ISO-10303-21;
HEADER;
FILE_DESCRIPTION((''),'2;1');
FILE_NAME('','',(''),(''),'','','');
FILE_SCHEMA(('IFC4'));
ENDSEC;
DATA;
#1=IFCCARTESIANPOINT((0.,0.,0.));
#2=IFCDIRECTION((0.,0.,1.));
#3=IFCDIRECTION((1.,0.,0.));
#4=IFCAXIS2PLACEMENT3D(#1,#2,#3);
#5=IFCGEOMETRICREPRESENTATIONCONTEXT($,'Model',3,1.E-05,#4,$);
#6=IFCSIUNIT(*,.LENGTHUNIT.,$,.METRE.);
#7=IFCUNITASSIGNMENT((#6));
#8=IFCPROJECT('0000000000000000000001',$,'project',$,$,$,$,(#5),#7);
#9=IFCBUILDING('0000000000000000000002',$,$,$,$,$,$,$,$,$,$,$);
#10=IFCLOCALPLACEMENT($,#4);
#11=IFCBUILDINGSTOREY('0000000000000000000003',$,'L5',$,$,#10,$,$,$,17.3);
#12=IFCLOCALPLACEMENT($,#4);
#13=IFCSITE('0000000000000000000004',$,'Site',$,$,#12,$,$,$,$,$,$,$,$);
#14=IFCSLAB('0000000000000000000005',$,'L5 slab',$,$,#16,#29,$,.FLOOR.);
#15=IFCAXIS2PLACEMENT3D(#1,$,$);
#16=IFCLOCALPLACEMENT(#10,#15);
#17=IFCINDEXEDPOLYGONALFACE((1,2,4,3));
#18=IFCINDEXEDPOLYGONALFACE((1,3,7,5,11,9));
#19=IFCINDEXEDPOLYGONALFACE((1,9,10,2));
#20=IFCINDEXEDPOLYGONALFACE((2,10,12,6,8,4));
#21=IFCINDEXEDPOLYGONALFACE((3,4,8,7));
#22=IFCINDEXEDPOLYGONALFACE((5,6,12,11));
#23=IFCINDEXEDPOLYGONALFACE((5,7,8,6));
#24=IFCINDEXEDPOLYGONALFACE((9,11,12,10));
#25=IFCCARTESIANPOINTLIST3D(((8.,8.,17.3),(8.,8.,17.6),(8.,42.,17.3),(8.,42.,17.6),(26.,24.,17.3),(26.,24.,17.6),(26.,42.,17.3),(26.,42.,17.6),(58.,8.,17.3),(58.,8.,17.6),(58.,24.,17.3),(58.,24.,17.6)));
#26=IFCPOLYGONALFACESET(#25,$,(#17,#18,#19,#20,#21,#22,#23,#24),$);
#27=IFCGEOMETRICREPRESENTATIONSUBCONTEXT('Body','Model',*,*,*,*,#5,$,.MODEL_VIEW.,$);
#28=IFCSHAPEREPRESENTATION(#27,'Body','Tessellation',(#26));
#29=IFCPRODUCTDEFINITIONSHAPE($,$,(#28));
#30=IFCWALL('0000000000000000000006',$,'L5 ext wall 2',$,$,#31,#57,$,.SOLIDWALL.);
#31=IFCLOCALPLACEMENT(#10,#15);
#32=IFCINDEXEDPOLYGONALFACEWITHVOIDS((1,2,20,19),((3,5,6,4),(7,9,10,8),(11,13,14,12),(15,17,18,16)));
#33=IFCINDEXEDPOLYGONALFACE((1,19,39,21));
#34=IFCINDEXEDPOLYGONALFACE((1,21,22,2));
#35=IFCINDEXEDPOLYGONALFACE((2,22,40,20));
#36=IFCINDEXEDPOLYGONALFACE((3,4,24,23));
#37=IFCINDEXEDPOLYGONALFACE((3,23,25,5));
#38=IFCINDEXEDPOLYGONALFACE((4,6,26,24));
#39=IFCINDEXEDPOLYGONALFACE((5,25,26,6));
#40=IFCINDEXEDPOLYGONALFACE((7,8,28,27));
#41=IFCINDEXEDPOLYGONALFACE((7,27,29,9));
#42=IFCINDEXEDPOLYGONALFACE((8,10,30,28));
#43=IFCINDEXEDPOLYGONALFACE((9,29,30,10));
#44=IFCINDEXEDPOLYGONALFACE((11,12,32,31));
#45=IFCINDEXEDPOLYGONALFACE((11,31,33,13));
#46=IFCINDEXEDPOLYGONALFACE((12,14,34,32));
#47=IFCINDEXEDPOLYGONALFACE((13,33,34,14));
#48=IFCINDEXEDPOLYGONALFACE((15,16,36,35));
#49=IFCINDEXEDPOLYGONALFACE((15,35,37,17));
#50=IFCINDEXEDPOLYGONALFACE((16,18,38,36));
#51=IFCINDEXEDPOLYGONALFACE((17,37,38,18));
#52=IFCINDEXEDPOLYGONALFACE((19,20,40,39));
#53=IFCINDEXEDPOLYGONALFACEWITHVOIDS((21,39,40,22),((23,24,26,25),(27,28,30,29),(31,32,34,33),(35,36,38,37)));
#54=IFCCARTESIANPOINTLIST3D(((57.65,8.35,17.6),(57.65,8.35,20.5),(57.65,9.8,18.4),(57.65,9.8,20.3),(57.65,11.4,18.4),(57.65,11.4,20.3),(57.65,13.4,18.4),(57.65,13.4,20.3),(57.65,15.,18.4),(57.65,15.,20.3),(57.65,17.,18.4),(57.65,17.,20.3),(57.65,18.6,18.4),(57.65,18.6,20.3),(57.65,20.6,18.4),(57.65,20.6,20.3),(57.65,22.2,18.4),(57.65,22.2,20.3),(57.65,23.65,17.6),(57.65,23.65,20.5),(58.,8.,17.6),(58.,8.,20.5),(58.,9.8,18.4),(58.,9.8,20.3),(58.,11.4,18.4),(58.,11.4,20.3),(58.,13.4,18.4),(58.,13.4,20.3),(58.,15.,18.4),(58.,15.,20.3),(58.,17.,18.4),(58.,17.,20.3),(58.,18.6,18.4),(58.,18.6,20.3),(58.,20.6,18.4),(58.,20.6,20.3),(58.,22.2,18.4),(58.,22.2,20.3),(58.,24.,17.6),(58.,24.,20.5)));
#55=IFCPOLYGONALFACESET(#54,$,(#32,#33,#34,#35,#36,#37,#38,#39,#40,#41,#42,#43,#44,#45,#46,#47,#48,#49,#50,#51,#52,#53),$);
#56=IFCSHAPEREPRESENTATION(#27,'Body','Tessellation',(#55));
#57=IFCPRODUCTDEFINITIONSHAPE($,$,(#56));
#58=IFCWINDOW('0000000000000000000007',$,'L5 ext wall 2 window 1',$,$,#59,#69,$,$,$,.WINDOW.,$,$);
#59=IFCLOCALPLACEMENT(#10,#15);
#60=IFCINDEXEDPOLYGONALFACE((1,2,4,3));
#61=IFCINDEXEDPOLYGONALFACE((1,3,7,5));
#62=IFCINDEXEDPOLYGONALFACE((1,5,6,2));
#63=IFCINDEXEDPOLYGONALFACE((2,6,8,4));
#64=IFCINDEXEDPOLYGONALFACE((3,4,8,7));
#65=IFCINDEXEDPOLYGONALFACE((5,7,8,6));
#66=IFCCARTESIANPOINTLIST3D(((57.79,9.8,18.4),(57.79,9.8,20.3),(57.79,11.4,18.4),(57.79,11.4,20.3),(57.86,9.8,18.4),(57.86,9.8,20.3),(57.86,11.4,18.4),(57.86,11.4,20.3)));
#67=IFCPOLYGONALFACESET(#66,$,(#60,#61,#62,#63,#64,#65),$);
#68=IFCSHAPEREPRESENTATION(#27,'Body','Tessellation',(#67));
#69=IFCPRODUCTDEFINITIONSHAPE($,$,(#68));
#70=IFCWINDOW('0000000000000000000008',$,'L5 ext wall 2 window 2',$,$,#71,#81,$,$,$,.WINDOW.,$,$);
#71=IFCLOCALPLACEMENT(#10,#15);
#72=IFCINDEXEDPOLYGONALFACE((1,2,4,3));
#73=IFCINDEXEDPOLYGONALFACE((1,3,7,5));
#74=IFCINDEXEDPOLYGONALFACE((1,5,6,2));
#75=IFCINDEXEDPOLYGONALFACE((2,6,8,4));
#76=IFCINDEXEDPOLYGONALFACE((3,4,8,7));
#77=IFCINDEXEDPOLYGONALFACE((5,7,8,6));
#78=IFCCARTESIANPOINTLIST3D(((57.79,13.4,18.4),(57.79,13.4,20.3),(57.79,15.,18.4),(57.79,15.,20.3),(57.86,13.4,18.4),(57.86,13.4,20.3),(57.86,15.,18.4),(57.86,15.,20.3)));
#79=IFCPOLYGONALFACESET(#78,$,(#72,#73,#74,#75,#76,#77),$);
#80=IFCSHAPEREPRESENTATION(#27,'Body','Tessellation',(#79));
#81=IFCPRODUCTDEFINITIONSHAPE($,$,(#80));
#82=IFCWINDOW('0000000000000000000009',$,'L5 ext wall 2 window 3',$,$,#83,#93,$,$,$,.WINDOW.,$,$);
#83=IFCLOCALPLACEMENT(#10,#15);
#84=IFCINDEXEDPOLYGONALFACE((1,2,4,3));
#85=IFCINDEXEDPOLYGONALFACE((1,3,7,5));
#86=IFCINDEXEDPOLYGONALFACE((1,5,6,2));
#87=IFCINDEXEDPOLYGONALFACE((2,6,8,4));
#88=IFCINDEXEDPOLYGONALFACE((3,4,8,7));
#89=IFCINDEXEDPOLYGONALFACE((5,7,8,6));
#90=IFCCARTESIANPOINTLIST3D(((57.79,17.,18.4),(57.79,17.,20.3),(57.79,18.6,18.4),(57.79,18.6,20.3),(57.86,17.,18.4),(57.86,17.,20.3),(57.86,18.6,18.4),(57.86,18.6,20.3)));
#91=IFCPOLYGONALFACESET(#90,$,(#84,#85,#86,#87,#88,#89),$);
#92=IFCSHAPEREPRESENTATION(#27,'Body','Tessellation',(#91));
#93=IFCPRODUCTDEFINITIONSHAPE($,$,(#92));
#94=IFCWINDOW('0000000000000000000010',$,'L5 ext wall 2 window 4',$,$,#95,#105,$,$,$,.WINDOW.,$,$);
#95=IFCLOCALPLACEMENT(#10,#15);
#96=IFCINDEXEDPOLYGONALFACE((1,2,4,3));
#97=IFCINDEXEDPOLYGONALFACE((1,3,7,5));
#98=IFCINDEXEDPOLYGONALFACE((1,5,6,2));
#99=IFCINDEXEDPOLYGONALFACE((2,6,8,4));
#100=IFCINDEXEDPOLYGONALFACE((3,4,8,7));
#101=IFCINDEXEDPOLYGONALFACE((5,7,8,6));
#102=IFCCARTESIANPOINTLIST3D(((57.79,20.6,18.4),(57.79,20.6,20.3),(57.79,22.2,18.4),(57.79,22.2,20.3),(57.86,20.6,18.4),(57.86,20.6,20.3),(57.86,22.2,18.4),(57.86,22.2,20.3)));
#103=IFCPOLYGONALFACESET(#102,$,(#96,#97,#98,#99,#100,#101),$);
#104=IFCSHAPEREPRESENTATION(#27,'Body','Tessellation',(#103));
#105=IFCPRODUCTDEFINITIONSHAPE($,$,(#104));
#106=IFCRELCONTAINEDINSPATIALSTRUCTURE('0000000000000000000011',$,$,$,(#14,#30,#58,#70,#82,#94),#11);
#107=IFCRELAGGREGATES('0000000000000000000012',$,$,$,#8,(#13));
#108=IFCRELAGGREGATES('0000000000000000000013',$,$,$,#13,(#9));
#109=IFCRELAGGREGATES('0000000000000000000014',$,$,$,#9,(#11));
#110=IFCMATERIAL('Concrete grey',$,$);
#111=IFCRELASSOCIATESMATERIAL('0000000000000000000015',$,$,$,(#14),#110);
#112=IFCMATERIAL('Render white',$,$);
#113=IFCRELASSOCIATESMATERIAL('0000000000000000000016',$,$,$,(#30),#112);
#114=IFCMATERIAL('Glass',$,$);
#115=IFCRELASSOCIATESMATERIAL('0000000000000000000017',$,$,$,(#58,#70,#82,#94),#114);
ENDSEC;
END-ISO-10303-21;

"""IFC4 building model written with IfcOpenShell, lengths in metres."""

from ifc_helpers import new_model, si_unit, frame, origin_with_axes, place, context, subcontext, project, spatial, polyline, outline, extrude, material, element, fill, save


model = new_model("IFC4")

# Units and contexts
model_context = context("Model", 3, precision=1e-05, world=origin_with_axes())
body_context = subcontext(model_context, "Body", "Model", "MODEL_VIEW")
ifc_project = project(units=[si_unit("LENGTHUNIT", "METRE")], contexts=[model_context])

# Site, building, storey
site_placement = place(None, origin_with_axes())
site = spatial("IfcSite", under=ifc_project, at=site_placement, Name="Site")
building = spatial("IfcBuilding", under=site)
storey_placement = place(None, origin_with_axes())
storey = spatial("IfcBuildingStorey", under=building, at=storey_placement, Name="L5", Elevation=17.3)

# Slab
ifc_material_1 = material(Name="Concrete grey")
slab_placement = place(storey_placement, origin_with_axes())
element("IfcSlab", 1, at=slab_placement, inside=storey, material=ifc_material_1, Name="L5 slab", PredefinedType="FLOOR", context=body_context, shape_type="SweptSolid", body=[
    extrude(outline(polyline([(8.0, 8.0), (58.0, 8.0), (58.0, 24.0), (26.0, 24.0), (26.0, 42.0), (8.0, 42.0), (8.0, 8.0)])), frame((0.0, 0.0, 17.3), z_axis=(0.0, 0.0, 1.0), x_axis=(1.0, 0.0, 0.0)), (0.0, 0.0, 1.0), 0.3),
])

# Wall, openings, windows
ifc_material_2 = material(Name="Render white")
ifc_material_3 = material(Name="Glass")
wall_1_placement = place(storey_placement, origin_with_axes())
wall_1 = element("IfcWall", 2, at=wall_1_placement, inside=storey, material=ifc_material_2, Name="L5 ext wall 2", PredefinedType="SOLIDWALL", context=body_context, shape_type="SweptSolid", body=[
    extrude(outline(polyline([(58.0, 8.0), (58.0, 24.0), (57.65, 23.65), (57.65, 8.35), (58.0, 8.0)])), frame((0.0, 0.0, 17.6), z_axis=(0.0, 0.0, 1.0), x_axis=(1.0, 0.0, 0.0)), (0.0, 0.0, 1.0), 2.9),
])
opening_1_placement = place(wall_1_placement, origin_with_axes())
opening_1 = element("IfcOpeningElement", 3, at=opening_1_placement, cuts=wall_1, context=body_context, shape_type="SweptSolid", body=[
    extrude(outline(polyline([(58.05, 9.8), (58.05, 11.4), (57.6, 11.4), (57.6, 9.8), (58.05, 9.8)])), frame((0.0, 0.0, 18.4), z_axis=(0.0, 0.0, 1.0), x_axis=(1.0, 0.0, 0.0)), (0.0, 0.0, 1.0), 1.9),
])
opening_2_placement = place(wall_1_placement, origin_with_axes())
opening_2 = element("IfcOpeningElement", 4, at=opening_2_placement, cuts=wall_1, context=body_context, shape_type="SweptSolid", body=[
    extrude(outline(polyline([(58.05, 13.4), (58.05, 15.0), (57.6, 15.0), (57.6, 13.4), (58.05, 13.4)])), frame((0.0, 0.0, 18.4), z_axis=(0.0, 0.0, 1.0), x_axis=(1.0, 0.0, 0.0)), (0.0, 0.0, 1.0), 1.9),
])
opening_3_placement = place(wall_1_placement, origin_with_axes())
opening_3 = element("IfcOpeningElement", 5, at=opening_3_placement, cuts=wall_1, context=body_context, shape_type="SweptSolid", body=[
    extrude(outline(polyline([(58.05, 17.0), (58.05, 18.6), (57.6, 18.6), (57.6, 17.0), (58.05, 17.0)])), frame((0.0, 0.0, 18.4), z_axis=(0.0, 0.0, 1.0), x_axis=(1.0, 0.0, 0.0)), (0.0, 0.0, 1.0), 1.9),
])
opening_4_placement = place(wall_1_placement, origin_with_axes())
opening_4 = element("IfcOpeningElement", 6, at=opening_4_placement, cuts=wall_1, context=body_context, shape_type="SweptSolid", body=[
    extrude(outline(polyline([(58.05, 20.6), (58.05, 22.2), (57.6, 22.2), (57.6, 20.6), (58.05, 20.6)])), frame((0.0, 0.0, 18.4), z_axis=(0.0, 0.0, 1.0), x_axis=(1.0, 0.0, 0.0)), (0.0, 0.0, 1.0), 1.9),
])
window_1_placement = place(storey_placement, origin_with_axes())
window_1 = element("IfcWindow", 7, at=window_1_placement, inside=storey, material=ifc_material_3, Name="L5 ext wall 2 window 1", PredefinedType="WINDOW", context=body_context, shape_type="SweptSolid", body=[
    extrude(outline(polyline([(57.86, 9.8), (57.86, 11.4), (57.79, 11.4), (57.79, 9.8), (57.86, 9.8)])), frame((0.0, 0.0, 18.4), z_axis=(0.0, 0.0, 1.0), x_axis=(1.0, 0.0, 0.0)), (0.0, 0.0, 1.0), 1.9),
])
fill(opening_1, window_1)
window_2_placement = place(storey_placement, origin_with_axes())
window_2 = element("IfcWindow", 8, at=window_2_placement, inside=storey, material=ifc_material_3, Name="L5 ext wall 2 window 2", PredefinedType="WINDOW", context=body_context, shape_type="SweptSolid", body=[
    extrude(outline(polyline([(57.86, 13.4), (57.86, 15.0), (57.79, 15.0), (57.79, 13.4), (57.86, 13.4)])), frame((0.0, 0.0, 18.4), z_axis=(0.0, 0.0, 1.0), x_axis=(1.0, 0.0, 0.0)), (0.0, 0.0, 1.0), 1.9),
])
fill(opening_2, window_2)
window_3_placement = place(storey_placement, origin_with_axes())
window_3 = element("IfcWindow", 9, at=window_3_placement, inside=storey, material=ifc_material_3, Name="L5 ext wall 2 window 3", PredefinedType="WINDOW", context=body_context, shape_type="SweptSolid", body=[
    extrude(outline(polyline([(57.86, 17.0), (57.86, 18.6), (57.79, 18.6), (57.79, 17.0), (57.86, 17.0)])), frame((0.0, 0.0, 18.4), z_axis=(0.0, 0.0, 1.0), x_axis=(1.0, 0.0, 0.0)), (0.0, 0.0, 1.0), 1.9),
])
fill(opening_3, window_3)
window_4_placement = place(storey_placement, origin_with_axes())
window_4 = element("IfcWindow", 10, at=window_4_placement, inside=storey, material=ifc_material_3, Name="L5 ext wall 2 window 4", PredefinedType="WINDOW", context=body_context, shape_type="SweptSolid", body=[
    extrude(outline(polyline([(57.86, 20.6), (57.86, 22.2), (57.79, 22.2), (57.79, 20.6), (57.86, 20.6)])), frame((0.0, 0.0, 18.4), z_axis=(0.0, 0.0, 1.0), x_axis=(1.0, 0.0, 0.0)), (0.0, 0.0, 1.0), 1.9),
])
fill(opening_4, window_4)

save(model, "model.ifc")
